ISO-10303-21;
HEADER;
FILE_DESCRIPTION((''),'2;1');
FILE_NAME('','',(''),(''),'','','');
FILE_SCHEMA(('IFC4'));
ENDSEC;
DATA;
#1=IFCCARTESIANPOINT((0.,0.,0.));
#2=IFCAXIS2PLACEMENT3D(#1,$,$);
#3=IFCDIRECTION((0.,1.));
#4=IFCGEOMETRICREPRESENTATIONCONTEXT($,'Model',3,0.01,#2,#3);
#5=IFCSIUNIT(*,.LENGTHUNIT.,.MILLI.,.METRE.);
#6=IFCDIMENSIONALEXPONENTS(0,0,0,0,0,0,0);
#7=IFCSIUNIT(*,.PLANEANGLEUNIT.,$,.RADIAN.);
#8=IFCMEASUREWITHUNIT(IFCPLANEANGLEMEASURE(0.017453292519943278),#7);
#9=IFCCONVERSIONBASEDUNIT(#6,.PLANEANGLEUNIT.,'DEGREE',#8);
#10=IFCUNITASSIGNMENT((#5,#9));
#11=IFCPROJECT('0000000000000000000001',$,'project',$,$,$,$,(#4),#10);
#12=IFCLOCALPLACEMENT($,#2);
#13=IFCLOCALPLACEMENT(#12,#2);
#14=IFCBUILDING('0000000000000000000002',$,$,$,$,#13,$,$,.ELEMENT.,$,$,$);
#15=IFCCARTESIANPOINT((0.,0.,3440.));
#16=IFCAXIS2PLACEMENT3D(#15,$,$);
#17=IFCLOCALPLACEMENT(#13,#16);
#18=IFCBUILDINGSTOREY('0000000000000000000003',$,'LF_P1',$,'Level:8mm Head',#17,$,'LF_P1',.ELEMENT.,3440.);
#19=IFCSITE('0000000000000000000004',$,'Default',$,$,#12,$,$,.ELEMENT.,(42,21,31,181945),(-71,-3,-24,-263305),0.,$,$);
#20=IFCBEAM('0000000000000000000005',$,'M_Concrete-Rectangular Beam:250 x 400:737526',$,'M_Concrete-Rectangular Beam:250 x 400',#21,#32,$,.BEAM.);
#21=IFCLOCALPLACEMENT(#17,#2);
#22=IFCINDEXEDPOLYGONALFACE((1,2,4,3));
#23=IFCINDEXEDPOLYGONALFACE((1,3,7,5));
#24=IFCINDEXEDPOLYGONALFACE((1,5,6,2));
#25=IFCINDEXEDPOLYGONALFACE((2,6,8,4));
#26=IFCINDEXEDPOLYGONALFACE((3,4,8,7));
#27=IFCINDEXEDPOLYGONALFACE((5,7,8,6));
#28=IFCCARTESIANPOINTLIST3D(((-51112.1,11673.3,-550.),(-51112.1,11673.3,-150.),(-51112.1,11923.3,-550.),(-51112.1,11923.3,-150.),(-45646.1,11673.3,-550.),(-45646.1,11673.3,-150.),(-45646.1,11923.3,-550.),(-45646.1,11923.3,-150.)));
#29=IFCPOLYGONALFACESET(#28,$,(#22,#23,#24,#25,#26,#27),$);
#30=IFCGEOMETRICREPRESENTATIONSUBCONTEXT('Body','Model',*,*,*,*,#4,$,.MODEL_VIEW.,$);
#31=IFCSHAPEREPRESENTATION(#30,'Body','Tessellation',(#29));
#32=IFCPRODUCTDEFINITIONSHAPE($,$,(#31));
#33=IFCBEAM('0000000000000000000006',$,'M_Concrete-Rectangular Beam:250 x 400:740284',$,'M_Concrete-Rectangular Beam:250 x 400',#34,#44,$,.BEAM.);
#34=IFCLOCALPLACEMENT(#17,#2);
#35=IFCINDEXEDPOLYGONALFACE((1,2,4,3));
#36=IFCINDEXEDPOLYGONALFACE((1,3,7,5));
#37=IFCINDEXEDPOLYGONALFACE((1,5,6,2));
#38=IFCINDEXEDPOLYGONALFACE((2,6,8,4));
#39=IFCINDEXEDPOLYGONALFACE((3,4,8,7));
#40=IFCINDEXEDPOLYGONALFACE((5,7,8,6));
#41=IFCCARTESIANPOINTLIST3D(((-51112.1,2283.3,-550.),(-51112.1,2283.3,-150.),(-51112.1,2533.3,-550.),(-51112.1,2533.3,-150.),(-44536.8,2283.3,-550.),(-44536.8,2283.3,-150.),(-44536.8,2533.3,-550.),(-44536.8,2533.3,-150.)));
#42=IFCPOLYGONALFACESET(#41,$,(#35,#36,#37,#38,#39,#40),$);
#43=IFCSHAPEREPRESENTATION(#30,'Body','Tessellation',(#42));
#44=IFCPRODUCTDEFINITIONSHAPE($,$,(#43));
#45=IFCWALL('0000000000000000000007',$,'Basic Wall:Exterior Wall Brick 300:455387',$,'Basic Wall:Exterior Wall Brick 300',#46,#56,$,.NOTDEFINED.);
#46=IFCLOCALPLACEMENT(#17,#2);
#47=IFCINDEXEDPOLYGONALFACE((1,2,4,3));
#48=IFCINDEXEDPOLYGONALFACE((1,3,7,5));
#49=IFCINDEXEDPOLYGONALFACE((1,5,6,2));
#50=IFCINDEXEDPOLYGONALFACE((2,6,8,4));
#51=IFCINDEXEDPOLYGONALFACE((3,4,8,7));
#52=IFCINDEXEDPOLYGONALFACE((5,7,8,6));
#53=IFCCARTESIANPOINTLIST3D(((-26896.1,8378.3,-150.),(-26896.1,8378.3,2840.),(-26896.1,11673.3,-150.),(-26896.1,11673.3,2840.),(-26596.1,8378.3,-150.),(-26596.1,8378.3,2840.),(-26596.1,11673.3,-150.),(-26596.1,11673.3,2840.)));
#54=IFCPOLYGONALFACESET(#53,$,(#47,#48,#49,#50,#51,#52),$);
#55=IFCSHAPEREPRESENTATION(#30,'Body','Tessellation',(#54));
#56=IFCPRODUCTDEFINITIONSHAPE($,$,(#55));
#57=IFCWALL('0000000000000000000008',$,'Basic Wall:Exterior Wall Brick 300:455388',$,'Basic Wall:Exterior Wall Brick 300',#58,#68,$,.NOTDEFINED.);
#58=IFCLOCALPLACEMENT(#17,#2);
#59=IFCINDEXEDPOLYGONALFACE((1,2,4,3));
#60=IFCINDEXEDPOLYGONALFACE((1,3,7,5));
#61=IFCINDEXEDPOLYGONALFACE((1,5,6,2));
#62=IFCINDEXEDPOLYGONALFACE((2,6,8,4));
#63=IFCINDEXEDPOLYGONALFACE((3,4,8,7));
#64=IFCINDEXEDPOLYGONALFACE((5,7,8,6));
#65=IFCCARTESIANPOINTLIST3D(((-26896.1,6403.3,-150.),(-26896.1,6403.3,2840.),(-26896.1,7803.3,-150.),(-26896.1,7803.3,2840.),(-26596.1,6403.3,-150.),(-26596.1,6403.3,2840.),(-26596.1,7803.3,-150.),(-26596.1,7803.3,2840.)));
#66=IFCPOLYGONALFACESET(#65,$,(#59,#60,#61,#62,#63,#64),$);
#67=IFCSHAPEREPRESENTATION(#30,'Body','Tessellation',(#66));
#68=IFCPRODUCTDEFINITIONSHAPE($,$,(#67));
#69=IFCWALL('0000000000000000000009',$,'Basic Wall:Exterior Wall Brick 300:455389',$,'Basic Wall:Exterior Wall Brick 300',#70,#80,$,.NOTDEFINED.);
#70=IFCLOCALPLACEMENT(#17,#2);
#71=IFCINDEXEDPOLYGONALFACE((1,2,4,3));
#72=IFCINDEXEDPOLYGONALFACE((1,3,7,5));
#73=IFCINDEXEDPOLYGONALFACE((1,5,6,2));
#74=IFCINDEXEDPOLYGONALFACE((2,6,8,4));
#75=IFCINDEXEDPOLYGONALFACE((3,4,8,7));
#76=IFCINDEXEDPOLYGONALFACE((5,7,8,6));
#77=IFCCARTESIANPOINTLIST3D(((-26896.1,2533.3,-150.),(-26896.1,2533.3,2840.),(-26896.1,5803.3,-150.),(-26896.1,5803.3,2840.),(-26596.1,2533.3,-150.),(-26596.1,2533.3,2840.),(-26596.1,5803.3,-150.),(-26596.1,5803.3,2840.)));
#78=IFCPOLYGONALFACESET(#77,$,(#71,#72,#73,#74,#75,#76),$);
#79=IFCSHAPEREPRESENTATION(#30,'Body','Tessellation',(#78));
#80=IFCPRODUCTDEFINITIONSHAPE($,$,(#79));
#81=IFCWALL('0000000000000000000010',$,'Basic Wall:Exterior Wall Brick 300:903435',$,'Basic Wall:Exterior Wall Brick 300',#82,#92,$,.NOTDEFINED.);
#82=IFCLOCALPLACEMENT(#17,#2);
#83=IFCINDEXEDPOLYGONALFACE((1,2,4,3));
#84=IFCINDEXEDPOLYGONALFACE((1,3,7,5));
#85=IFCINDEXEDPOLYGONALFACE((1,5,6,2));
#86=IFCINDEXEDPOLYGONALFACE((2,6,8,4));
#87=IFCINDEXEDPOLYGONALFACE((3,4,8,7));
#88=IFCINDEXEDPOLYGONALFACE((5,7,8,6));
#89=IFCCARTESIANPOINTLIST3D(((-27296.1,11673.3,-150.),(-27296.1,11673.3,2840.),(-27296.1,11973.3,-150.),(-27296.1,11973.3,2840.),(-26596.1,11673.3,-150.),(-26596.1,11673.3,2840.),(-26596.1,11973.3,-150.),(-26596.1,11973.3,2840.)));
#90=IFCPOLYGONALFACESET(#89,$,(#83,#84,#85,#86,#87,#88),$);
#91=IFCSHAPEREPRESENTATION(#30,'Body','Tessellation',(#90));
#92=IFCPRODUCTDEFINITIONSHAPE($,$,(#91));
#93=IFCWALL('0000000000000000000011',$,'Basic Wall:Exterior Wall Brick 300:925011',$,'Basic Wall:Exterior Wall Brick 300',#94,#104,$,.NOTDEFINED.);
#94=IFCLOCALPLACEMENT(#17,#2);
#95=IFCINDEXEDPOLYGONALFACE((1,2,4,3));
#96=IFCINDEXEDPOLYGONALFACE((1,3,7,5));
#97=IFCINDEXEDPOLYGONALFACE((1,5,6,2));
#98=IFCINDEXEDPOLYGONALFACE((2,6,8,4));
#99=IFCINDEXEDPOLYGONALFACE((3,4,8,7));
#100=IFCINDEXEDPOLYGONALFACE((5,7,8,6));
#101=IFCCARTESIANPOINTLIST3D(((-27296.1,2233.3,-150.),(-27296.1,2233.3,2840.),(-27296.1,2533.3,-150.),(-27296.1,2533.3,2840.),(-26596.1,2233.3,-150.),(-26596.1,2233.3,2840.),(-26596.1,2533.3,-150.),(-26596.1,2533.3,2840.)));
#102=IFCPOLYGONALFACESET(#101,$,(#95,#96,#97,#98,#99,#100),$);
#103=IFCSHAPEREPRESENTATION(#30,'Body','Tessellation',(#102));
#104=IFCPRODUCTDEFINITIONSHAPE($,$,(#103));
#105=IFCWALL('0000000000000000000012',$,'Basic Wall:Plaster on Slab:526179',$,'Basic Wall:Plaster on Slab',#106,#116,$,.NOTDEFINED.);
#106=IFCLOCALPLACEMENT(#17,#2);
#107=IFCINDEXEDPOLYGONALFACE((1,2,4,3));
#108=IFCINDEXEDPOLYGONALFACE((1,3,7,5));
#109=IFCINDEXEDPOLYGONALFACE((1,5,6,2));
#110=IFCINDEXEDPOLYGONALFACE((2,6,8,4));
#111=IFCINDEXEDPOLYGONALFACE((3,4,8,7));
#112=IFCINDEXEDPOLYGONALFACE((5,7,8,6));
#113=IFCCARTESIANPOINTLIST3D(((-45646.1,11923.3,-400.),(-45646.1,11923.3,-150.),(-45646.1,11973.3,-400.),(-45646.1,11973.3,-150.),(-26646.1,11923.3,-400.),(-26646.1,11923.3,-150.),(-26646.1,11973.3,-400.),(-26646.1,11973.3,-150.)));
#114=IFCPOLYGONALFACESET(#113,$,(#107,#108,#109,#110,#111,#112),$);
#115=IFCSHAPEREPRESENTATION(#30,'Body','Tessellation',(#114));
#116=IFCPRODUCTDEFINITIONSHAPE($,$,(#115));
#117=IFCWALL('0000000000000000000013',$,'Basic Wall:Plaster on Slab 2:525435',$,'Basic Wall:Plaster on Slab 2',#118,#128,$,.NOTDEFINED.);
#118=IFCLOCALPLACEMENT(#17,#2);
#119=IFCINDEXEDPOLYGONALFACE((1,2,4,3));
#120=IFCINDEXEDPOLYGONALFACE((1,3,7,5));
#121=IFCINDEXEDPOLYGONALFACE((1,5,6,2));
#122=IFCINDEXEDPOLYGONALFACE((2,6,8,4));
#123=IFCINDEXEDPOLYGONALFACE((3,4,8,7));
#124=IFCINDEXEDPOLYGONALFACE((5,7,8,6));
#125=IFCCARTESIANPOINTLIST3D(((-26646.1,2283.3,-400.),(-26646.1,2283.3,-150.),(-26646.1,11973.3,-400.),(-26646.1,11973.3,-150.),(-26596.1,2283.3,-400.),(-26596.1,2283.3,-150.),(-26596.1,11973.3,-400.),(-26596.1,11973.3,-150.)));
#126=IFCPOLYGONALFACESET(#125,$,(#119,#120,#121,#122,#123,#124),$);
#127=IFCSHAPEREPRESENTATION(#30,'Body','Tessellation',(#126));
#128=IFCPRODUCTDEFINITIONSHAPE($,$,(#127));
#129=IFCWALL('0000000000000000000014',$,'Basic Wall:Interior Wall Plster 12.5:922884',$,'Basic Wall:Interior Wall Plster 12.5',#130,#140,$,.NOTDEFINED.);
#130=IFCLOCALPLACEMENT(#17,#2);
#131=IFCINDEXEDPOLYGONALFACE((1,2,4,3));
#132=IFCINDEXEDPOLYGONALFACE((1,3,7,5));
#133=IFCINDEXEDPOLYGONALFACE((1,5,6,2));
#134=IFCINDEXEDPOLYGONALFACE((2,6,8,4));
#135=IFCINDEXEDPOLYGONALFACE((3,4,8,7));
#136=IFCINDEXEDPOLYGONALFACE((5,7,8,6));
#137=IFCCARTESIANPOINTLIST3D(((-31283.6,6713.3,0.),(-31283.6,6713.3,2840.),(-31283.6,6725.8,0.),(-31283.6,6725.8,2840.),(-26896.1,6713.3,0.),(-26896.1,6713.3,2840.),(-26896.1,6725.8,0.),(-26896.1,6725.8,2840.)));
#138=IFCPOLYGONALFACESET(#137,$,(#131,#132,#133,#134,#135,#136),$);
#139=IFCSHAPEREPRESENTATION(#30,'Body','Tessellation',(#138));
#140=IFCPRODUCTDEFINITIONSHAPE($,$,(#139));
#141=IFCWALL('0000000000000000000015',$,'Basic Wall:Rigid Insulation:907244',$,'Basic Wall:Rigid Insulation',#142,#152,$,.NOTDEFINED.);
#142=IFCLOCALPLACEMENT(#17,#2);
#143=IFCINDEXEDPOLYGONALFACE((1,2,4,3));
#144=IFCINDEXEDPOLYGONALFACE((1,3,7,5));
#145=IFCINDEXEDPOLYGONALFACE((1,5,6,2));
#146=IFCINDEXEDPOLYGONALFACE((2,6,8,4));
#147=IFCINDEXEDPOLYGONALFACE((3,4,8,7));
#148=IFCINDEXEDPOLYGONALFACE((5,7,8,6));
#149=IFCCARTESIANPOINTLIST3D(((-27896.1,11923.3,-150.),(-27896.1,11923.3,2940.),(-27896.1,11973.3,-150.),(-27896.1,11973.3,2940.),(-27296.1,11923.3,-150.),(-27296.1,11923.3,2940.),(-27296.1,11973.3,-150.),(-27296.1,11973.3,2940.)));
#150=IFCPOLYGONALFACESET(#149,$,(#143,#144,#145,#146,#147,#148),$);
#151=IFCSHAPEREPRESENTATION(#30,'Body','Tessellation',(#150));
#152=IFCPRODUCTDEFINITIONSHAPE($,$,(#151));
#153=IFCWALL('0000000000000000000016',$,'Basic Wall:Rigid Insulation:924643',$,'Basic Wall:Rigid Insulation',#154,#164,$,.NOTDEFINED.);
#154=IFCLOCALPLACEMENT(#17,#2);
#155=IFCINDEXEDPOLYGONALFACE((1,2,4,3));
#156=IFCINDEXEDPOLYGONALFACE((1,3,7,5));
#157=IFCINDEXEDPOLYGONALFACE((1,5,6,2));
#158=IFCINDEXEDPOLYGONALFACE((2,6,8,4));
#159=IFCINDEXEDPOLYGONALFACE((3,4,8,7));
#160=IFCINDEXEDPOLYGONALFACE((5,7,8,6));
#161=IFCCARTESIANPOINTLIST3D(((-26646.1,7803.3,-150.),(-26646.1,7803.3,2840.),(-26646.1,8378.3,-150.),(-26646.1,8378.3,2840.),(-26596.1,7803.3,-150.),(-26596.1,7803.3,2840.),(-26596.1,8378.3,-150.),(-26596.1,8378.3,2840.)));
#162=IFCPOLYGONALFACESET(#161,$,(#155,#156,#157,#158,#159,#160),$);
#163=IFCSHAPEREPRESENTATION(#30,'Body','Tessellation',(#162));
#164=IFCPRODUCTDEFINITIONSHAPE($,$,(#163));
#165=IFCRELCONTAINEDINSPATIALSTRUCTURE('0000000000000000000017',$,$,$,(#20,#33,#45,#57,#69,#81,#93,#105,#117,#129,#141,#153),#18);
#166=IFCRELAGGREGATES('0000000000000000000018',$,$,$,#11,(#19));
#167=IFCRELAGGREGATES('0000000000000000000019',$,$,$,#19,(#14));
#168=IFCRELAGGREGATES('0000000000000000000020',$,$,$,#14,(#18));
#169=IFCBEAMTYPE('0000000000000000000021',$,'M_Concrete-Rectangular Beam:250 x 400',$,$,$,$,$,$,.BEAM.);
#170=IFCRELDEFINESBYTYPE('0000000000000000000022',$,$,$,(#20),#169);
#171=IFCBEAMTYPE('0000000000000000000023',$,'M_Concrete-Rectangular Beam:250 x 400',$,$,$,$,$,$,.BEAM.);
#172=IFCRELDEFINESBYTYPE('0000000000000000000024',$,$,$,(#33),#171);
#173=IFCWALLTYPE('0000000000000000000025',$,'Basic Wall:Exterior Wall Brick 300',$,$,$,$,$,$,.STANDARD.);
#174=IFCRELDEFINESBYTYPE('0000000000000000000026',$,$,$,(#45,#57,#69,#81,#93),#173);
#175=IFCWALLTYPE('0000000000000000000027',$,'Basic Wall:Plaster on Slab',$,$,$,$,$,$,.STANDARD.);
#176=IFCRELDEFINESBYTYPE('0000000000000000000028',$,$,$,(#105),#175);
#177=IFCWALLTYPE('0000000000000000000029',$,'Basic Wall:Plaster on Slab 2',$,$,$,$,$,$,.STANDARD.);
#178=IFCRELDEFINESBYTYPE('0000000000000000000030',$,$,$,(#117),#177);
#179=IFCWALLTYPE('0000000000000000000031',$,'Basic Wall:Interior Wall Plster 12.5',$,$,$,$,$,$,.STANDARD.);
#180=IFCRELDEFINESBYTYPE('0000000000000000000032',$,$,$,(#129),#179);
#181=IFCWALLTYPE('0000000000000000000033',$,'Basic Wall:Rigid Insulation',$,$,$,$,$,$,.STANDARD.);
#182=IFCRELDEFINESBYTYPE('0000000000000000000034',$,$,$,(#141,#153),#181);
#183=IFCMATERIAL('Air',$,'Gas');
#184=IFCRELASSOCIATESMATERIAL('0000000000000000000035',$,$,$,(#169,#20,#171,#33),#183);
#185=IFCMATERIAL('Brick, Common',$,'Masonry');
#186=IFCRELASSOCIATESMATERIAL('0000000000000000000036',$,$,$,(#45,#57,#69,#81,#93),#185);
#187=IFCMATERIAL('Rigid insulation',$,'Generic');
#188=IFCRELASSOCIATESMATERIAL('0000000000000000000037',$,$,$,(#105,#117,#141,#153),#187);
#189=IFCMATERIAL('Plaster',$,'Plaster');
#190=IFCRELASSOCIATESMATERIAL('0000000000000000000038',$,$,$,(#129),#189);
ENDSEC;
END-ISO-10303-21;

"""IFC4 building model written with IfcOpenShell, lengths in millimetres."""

from ifc_helpers import new_model, entity, si_unit, converted_unit, direction, frame, origin, place, context, subcontext, project, spatial, indexed_curve, outline, extrude, source, transform, mapped, material, type_object, type_shapes, element, save


model = new_model("IFC4")

# Units and contexts
model_context = context("Model", 3, precision=0.01, world=origin(), true_north=direction((0.0, 1.0)))
body_context = subcontext(model_context, "Body", "Model", "MODEL_VIEW")
ifc_project = project(units=[si_unit("LENGTHUNIT", "METRE", prefix="MILLI"), converted_unit("PLANEANGLEUNIT", "DEGREE", entity("IfcPlaneAngleMeasure", 0.017453292519943278), si_unit("PLANEANGLEUNIT", "RADIAN"), dimensions=[0, 0, 0, 0, 0, 0, 0])], contexts=[model_context])

# Site, building, storey
site_placement = place(None, origin())
site = spatial("IfcSite", under=ifc_project, at=site_placement, Name="Default", CompositionType="ELEMENT", RefLatitude=(42, 21, 31, 181945), RefLongitude=(-71, -3, -24, -263305), RefElevation=0.0)
building_placement = place(site_placement, origin())
building = spatial("IfcBuilding", under=site, at=building_placement, CompositionType="ELEMENT")
storey_placement = place(building_placement, frame((0.0, 0.0, 3440.0)))
storey = spatial("IfcBuildingStorey", under=building, at=storey_placement, Name="LF_P1", ObjectType="Level:8mm Head", LongName="LF_P1", CompositionType="ELEMENT", Elevation=3440.0)

# Beams
ifc_material_1 = material(Name="Air", Category="Gas")
beam_type_1 = type_object("IfcBeamType", Name="M_Concrete-Rectangular Beam:250 x 400", PredefinedType="BEAM", material=ifc_material_1)
shared_shape_1 = source(origin(), body_context, "Body", "SweptSolid", [
    extrude(outline(indexed_curve([(-200.0, -125.0), (200.0, -125.0), (200.0, 125.0), (-200.0, 125.0), (-200.0, -125.0)], self_intersect=False)), frame((-51112.1, 11798.3, 3090.0), z_axis=(1.0, 0.0, 0.0), x_axis=(0.0, 0.0, -1.0)), (0.0, 0.0, 1.0), 5466.0),
])
type_shapes(beam_type_1, [shared_shape_1])
beam_1_placement = place(storey_placement, frame((0.0, 0.0, -3440.0)))
element("IfcBeam", 1, at=beam_1_placement, inside=storey, type_object=beam_type_1, material=ifc_material_1, Name="M_Concrete-Rectangular Beam:250 x 400:737526", ObjectType="M_Concrete-Rectangular Beam:250 x 400", PredefinedType="BEAM", context=body_context, shape_type="MappedRepresentation", body=[
    mapped(shared_shape_1, transform((0.0, 0.0, 0.0), scale=1.0)),
])
beam_type_2 = type_object("IfcBeamType", Name="M_Concrete-Rectangular Beam:250 x 400", PredefinedType="BEAM", material=ifc_material_1)
shared_shape_2 = source(origin(), body_context, "Body", "SweptSolid", [
    extrude(outline(indexed_curve([(-200.0, -125.0), (200.0, -125.0), (200.0, 125.0), (-200.0, 125.0), (-200.0, -125.0)], self_intersect=False)), frame((-44536.8, 2408.3, 3090.0), z_axis=(-1.0, 0.0, 0.0), x_axis=(0.0, 0.0, -1.0)), (0.0, 0.0, 1.0), 6575.3),
])
type_shapes(beam_type_2, [shared_shape_2])
beam_2_placement = place(storey_placement, frame((0.0, 0.0, -3440.0)))
element("IfcBeam", 2, at=beam_2_placement, inside=storey, type_object=beam_type_2, material=ifc_material_1, Name="M_Concrete-Rectangular Beam:250 x 400:740284", ObjectType="M_Concrete-Rectangular Beam:250 x 400", PredefinedType="BEAM", context=body_context, shape_type="MappedRepresentation", body=[
    mapped(shared_shape_2, transform((0.0, 0.0, 0.0), scale=1.0)),
])

# Walls
ifc_material_2 = material(Name="Brick, Common", Category="Masonry")
wall_type_1 = type_object("IfcWallType", Name="Basic Wall:Exterior Wall Brick 300", PredefinedType="STANDARD")
wall_1_placement = place(storey_placement, frame((-26746.1, 11673.3, -150.0), z_axis=(0.0, 0.0, 1.0), x_axis=(0.0, -1.0, 0.0)))
element("IfcWall", 3, at=wall_1_placement, inside=storey, type_object=wall_type_1, material=ifc_material_2, Name="Basic Wall:Exterior Wall Brick 300:455387", ObjectType="Basic Wall:Exterior Wall Brick 300", PredefinedType="NOTDEFINED", context=body_context, shape_type="SweptSolid", body=[
    extrude(outline(indexed_curve([(3295.0, 150.0), (0.0, 150.0), (0.0, -150.0), (3295.0, -150.0), (3295.0, 150.0)], self_intersect=False)), origin(), (0.0, 0.0, 1.0), 2990.0),
])
wall_2_placement = place(storey_placement, frame((-26746.1, 7803.3, -150.0), z_axis=(0.0, 0.0, 1.0), x_axis=(0.0, -1.0, 0.0)))
element("IfcWall", 4, at=wall_2_placement, inside=storey, type_object=wall_type_1, material=ifc_material_2, Name="Basic Wall:Exterior Wall Brick 300:455388", ObjectType="Basic Wall:Exterior Wall Brick 300", PredefinedType="NOTDEFINED", context=body_context, shape_type="SweptSolid", body=[
    extrude(outline(indexed_curve([(1400.0, 150.0), (0.0, 150.0), (0.0, -150.0), (1400.0, -150.0), (1400.0, 150.0)], self_intersect=False)), origin(), (0.0, 0.0, 1.0), 2990.0),
])
wall_3_placement = place(storey_placement, frame((-26746.1, 5803.3, -150.0), z_axis=(0.0, 0.0, 1.0), x_axis=(0.0, -1.0, 0.0)))
element("IfcWall", 5, at=wall_3_placement, inside=storey, type_object=wall_type_1, material=ifc_material_2, Name="Basic Wall:Exterior Wall Brick 300:455389", ObjectType="Basic Wall:Exterior Wall Brick 300", PredefinedType="NOTDEFINED", context=body_context, shape_type="SweptSolid", body=[
    extrude(outline(indexed_curve([(3270.0, 150.0), (0.0, 150.0), (0.0, -150.0), (3270.0, -150.0), (3270.0, 150.0)], self_intersect=False)), origin(), (0.0, 0.0, 1.0), 2990.0),
])
wall_4_placement = place(storey_placement, frame((-27296.1, 11823.3, -150.0)))
element("IfcWall", 6, at=wall_4_placement, inside=storey, type_object=wall_type_1, material=ifc_material_2, Name="Basic Wall:Exterior Wall Brick 300:903435", ObjectType="Basic Wall:Exterior Wall Brick 300", PredefinedType="NOTDEFINED", context=body_context, shape_type="SweptSolid", body=[
    extrude(outline(indexed_curve([(700.0, 150.0), (0.0, 150.0), (0.0, -150.0), (700.0, -150.0), (700.0, 150.0)], self_intersect=False)), origin(), (0.0, 0.0, 1.0), 2990.0),
])
wall_5_placement = place(storey_placement, frame((-26596.1, 2383.3, -150.0), z_axis=(0.0, 0.0, 1.0), x_axis=(-1.0, 0.0, 0.0)))
element("IfcWall", 7, at=wall_5_placement, inside=storey, type_object=wall_type_1, material=ifc_material_2, Name="Basic Wall:Exterior Wall Brick 300:925011", ObjectType="Basic Wall:Exterior Wall Brick 300", PredefinedType="NOTDEFINED", context=body_context, shape_type="SweptSolid", body=[
    extrude(outline(indexed_curve([(700.0, 150.0), (0.0, 150.0), (0.0, -150.0), (700.0, -150.0), (700.0, 150.0)], self_intersect=False)), origin(), (0.0, 0.0, 1.0), 2990.0),
])
ifc_material_3 = material(Name="Rigid insulation", Category="Generic")
wall_type_2 = type_object("IfcWallType", Name="Basic Wall:Plaster on Slab", PredefinedType="STANDARD")
wall_6_placement = place(storey_placement, frame((-26646.1, 11948.3, -400.0), z_axis=(0.0, 0.0, 1.0), x_axis=(-1.0, 0.0, 0.0)))
element("IfcWall", 8, at=wall_6_placement, inside=storey, type_object=wall_type_2, material=ifc_material_3, Name="Basic Wall:Plaster on Slab:526179", ObjectType="Basic Wall:Plaster on Slab", PredefinedType="NOTDEFINED", context=body_context, shape_type="SweptSolid", body=[
    extrude(outline(indexed_curve([(19000.0, 25.0), (0.0, 25.0), (0.0, -25.0), (19000.0, -25.0), (19000.0, 25.0)], self_intersect=False)), origin(), (0.0, 0.0, 1.0), 250.0),
])
wall_type_3 = type_object("IfcWallType", Name="Basic Wall:Plaster on Slab 2", PredefinedType="STANDARD")
wall_7_placement = place(storey_placement, frame((-26621.1, 2283.3, -400.0), z_axis=(0.0, 0.0, 1.0), x_axis=(0.0, 1.0, 0.0)))
element("IfcWall", 9, at=wall_7_placement, inside=storey, type_object=wall_type_3, material=ifc_material_3, Name="Basic Wall:Plaster on Slab 2:525435", ObjectType="Basic Wall:Plaster on Slab 2", PredefinedType="NOTDEFINED", context=body_context, shape_type="SweptSolid", body=[
    extrude(outline(indexed_curve([(9690.0, 25.0), (0.0, 25.0), (0.0, -25.0), (9690.0, -25.0), (9690.0, 25.0)], self_intersect=False)), origin(), (0.0, 0.0, 1.0), 250.0),
])
ifc_material_4 = material(Name="Plaster", Category="Plaster")
wall_type_4 = type_object("IfcWallType", Name="Basic Wall:Interior Wall Plster 12.5", PredefinedType="STANDARD")
wall_8_placement = place(storey_placement, frame((-26896.1, 6719.6, 0.0), z_axis=(0.0, 0.0, 1.0), x_axis=(-1.0, 0.0, 0.0)))
element("IfcWall", 10, at=wall_8_placement, inside=storey, type_object=wall_type_4, material=ifc_material_4, Name="Basic Wall:Interior Wall Plster 12.5:922884", ObjectType="Basic Wall:Interior Wall Plster 12.5", PredefinedType="NOTDEFINED", context=body_context, shape_type="SweptSolid", body=[
    extrude(outline(indexed_curve([(4387.5, 6.3), (0.0, 6.2), (0.0, -6.2), (4387.5, -6.2), (4387.5, 6.3)], self_intersect=False)), origin(), (0.0, 0.0, 1.0), 2840.0),
])
wall_type_5 = type_object("IfcWallType", Name="Basic Wall:Rigid Insulation", PredefinedType="STANDARD")
wall_9_placement = place(storey_placement, frame((-27896.1, 11948.3, -150.0)))
element("IfcWall", 11, at=wall_9_placement, inside=storey, type_object=wall_type_5, material=ifc_material_3, Name="Basic Wall:Rigid Insulation:907244", ObjectType="Basic Wall:Rigid Insulation", PredefinedType="NOTDEFINED", context=body_context, shape_type="SweptSolid", body=[
    extrude(outline(indexed_curve([(600.0, 25.0), (0.0, 25.0), (0.0, -25.0), (600.0, -25.0), (600.0, 25.0)], self_intersect=False)), origin(), (0.0, 0.0, 1.0), 3090.0),
])
wall_10_placement = place(storey_placement, frame((-26621.1, 8378.3, -150.0), z_axis=(0.0, 0.0, 1.0), x_axis=(0.0, -1.0, 0.0)))
element("IfcWall", 12, at=wall_10_placement, inside=storey, type_object=wall_type_5, material=ifc_material_3, Name="Basic Wall:Rigid Insulation:924643", ObjectType="Basic Wall:Rigid Insulation", PredefinedType="NOTDEFINED", context=body_context, shape_type="SweptSolid", body=[
    extrude(outline(indexed_curve([(575.0, 25.0), (0.0, 25.0), (0.0, -25.0), (575.0, -25.0), (575.0, 25.0)], self_intersect=False)), origin(), (0.0, 0.0, 1.0), 2990.0),
])

save(model, "model.ifc")
